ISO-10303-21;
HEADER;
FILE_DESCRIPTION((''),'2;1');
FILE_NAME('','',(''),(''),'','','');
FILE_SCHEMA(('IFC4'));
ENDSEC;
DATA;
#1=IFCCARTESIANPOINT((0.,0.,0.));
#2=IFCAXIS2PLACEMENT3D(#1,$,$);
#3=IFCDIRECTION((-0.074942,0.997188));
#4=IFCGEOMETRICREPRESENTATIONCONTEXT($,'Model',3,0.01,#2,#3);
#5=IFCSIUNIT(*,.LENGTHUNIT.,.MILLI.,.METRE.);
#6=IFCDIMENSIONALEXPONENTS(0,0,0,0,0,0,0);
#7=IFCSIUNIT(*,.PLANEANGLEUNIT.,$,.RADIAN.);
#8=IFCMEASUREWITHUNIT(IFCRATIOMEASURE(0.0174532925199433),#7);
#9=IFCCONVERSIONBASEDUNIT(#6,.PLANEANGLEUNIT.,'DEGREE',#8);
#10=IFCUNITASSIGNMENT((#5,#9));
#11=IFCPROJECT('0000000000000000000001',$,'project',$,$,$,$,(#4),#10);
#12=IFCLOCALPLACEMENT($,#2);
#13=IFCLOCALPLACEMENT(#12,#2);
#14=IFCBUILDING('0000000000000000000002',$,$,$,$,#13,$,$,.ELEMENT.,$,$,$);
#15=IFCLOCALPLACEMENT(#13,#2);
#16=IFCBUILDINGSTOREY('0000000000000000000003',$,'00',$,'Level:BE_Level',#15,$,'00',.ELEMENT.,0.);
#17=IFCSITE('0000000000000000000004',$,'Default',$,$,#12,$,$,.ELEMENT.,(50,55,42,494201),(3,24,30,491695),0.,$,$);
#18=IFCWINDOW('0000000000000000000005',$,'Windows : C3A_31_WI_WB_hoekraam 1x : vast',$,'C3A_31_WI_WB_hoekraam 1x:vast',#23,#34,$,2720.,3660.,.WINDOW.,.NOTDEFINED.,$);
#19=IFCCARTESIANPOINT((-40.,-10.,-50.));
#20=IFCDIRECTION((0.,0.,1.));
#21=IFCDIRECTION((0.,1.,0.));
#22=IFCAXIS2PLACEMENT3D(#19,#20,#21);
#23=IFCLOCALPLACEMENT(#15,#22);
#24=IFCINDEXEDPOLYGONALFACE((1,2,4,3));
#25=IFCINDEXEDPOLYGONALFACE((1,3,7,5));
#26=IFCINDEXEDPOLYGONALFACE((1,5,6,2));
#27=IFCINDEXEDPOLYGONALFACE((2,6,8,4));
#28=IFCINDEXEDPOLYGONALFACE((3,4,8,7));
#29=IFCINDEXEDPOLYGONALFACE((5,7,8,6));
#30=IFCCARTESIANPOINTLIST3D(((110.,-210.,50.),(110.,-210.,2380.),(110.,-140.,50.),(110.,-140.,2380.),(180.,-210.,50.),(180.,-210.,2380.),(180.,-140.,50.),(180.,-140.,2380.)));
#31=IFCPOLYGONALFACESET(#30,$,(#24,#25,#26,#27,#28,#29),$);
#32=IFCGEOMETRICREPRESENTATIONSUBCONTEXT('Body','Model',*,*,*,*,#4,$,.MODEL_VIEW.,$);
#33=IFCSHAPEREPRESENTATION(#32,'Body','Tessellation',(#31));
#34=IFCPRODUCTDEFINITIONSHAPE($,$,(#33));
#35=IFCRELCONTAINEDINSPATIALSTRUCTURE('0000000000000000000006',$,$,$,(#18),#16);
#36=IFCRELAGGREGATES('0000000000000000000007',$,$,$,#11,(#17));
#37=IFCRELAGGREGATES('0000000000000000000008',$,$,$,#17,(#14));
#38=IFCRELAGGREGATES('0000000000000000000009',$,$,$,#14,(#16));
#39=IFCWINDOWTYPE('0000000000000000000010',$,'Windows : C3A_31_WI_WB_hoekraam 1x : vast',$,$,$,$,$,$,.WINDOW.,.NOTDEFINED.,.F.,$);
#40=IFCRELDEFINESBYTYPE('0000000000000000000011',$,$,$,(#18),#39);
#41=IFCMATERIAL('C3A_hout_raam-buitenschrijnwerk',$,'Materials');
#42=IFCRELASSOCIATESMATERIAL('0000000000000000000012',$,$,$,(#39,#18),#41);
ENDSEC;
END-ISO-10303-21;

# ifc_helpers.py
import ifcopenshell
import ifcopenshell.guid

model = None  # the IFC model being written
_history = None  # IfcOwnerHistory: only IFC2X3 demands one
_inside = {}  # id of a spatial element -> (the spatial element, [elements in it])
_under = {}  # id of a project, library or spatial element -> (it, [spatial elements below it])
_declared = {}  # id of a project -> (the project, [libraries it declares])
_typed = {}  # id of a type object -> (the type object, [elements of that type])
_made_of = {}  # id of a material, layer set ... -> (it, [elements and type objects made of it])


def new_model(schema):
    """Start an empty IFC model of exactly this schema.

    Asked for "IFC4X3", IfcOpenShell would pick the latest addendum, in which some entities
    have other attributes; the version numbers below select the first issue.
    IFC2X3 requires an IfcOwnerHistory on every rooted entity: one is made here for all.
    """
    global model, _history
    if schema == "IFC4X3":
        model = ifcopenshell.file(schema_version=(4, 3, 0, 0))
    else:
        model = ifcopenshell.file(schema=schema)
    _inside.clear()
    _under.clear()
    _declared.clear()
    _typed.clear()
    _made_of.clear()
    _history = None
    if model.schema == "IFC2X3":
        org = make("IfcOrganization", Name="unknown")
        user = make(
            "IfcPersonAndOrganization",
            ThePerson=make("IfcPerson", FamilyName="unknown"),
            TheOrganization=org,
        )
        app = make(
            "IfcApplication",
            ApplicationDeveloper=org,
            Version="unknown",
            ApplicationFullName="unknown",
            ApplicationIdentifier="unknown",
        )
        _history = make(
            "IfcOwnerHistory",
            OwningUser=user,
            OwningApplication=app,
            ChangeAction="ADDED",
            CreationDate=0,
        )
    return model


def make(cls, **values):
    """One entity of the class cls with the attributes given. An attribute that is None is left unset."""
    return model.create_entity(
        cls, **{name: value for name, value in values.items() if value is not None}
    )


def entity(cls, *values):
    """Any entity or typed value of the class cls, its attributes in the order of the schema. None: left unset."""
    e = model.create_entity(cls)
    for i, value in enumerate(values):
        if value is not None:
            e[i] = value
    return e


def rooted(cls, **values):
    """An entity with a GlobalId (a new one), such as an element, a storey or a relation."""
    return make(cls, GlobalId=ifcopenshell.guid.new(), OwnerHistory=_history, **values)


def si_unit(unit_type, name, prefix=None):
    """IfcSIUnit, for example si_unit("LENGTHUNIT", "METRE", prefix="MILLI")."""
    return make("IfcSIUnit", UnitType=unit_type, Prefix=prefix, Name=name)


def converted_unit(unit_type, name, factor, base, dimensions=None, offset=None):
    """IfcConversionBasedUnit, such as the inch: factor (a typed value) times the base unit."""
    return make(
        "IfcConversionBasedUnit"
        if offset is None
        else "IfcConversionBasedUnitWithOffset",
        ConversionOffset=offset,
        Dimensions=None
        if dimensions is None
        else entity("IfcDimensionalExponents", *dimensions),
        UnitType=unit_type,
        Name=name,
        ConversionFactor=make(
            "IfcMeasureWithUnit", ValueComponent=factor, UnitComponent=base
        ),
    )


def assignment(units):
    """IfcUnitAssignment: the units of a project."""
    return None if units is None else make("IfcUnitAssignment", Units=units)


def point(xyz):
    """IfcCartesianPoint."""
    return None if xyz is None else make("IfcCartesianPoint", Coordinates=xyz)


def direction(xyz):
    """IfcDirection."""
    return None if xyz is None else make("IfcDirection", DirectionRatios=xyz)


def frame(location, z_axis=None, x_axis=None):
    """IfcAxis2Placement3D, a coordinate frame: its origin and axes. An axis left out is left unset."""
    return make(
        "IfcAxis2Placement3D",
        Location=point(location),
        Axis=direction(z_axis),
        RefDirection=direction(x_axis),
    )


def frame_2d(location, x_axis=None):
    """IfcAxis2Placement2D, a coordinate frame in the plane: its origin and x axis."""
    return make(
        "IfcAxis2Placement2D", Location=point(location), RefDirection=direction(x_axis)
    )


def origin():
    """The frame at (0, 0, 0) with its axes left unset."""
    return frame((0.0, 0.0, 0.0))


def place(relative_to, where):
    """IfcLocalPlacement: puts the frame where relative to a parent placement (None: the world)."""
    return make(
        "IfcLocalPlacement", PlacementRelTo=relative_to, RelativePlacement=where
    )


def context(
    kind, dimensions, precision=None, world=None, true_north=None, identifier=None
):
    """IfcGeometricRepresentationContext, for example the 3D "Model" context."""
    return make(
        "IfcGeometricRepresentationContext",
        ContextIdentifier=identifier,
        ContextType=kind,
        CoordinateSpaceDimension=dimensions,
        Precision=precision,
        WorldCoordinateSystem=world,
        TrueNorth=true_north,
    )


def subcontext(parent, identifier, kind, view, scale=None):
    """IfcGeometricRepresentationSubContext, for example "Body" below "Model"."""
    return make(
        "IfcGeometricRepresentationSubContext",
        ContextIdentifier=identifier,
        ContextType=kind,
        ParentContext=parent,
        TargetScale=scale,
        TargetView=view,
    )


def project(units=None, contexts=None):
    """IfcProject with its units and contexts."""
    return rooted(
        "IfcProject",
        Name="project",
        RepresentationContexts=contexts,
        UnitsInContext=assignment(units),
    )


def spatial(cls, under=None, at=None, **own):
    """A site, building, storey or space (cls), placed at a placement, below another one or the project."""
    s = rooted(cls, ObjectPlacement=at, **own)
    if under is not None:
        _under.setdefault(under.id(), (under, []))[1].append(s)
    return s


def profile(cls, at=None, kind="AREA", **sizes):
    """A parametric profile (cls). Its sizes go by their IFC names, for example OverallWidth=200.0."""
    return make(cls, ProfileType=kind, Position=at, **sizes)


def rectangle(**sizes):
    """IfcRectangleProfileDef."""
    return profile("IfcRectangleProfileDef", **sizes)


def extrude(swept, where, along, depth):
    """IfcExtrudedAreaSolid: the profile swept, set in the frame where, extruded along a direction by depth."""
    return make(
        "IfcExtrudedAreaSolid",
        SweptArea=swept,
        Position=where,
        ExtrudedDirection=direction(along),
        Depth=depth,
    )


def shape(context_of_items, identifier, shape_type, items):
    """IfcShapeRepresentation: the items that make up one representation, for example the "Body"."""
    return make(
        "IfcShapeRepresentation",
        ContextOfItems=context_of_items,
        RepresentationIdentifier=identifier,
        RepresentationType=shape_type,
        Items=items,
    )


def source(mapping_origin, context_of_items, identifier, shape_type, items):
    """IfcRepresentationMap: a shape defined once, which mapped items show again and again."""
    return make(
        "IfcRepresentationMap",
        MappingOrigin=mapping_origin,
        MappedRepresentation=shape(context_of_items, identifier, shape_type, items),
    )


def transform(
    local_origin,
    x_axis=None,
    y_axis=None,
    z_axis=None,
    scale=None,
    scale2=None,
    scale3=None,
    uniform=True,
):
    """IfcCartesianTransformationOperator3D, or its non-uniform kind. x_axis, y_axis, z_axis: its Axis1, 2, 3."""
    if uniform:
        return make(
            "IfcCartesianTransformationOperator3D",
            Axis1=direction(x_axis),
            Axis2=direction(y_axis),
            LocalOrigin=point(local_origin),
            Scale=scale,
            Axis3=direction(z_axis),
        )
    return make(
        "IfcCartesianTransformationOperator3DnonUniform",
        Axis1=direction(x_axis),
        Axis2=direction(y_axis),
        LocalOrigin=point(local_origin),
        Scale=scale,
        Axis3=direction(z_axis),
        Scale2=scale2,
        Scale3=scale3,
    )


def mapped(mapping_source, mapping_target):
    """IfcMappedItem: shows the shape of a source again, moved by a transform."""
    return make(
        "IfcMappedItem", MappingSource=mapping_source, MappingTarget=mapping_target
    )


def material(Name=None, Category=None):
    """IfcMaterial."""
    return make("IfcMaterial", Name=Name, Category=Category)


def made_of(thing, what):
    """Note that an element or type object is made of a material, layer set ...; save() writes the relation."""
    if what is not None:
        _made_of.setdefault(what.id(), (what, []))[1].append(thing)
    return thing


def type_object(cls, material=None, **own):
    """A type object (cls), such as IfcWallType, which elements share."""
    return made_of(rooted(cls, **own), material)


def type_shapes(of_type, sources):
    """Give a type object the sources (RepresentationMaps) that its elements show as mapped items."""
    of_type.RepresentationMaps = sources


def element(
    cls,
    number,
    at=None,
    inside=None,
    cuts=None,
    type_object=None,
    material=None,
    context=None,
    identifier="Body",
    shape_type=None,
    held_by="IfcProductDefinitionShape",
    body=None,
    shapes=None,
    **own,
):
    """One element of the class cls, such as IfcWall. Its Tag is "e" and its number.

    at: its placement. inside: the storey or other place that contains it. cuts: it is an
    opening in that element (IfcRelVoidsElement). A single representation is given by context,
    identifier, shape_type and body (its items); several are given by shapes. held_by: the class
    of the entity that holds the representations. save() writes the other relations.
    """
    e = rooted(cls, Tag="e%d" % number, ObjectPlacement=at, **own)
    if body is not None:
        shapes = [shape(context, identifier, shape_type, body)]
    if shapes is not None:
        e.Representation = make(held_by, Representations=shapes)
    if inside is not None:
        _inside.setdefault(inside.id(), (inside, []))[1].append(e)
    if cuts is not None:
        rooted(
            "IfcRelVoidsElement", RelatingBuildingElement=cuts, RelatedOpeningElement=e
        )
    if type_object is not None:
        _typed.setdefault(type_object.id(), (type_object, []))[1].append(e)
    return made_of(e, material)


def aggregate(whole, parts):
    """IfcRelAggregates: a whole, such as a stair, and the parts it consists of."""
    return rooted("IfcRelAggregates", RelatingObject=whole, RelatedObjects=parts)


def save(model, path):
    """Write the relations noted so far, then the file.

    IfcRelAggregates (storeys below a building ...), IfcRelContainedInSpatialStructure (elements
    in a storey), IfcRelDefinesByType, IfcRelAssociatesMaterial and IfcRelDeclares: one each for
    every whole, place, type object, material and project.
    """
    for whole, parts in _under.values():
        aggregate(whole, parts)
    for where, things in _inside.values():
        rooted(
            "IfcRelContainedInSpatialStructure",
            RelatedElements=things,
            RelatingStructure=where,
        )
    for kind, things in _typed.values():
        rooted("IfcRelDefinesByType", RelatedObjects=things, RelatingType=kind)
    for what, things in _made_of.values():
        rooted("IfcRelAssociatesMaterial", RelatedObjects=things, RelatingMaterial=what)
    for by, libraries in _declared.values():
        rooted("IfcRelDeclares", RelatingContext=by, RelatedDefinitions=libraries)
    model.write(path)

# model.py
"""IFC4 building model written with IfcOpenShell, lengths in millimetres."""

from ifc_helpers import new_model, entity, si_unit, converted_unit, direction, frame, frame_2d, origin, place, context, subcontext, project, spatial, rectangle, extrude, source, transform, mapped, material, type_object, type_shapes, element, save


model = new_model("IFC4")

# Units and contexts
model_context = context("Model", 3, precision=0.01, world=origin(), true_north=direction((-0.074942, 0.997188)))
body_context = subcontext(model_context, "Body", "Model", "MODEL_VIEW")
ifc_project = project(units=[si_unit("LENGTHUNIT", "METRE", prefix="MILLI"), converted_unit("PLANEANGLEUNIT", "DEGREE", entity("IfcRatioMeasure", 0.0174532925199433), si_unit("PLANEANGLEUNIT", "RADIAN"), dimensions=[0, 0, 0, 0, 0, 0, 0])], contexts=[model_context])

# Site, building, storey
site_placement = place(None, origin())
site = spatial("IfcSite", under=ifc_project, at=site_placement, Name="Default", CompositionType="ELEMENT", RefLatitude=(50, 55, 42, 494201), RefLongitude=(3, 24, 30, 491695), RefElevation=0.0)
building_placement = place(site_placement, origin())
building = spatial("IfcBuilding", under=site, at=building_placement, CompositionType="ELEMENT")
storey_placement = place(building_placement, frame((0.0, 0.0, 0.0)))
storey = spatial("IfcBuildingStorey", under=building, at=storey_placement, Name="00", ObjectType="Level:BE_Level", LongName="00", CompositionType="ELEMENT", Elevation=0.0)

# Window
ifc_material_1 = material(Name="C3A_hout_raam-buitenschrijnwerk", Category="Materials")
window_type = type_object("IfcWindowType", Name="Windows : C3A_31_WI_WB_hoekraam 1x : vast", ParameterTakesPrecedence=False, PartitioningType="NOTDEFINED", PredefinedType="WINDOW", material=ifc_material_1)
shared_shape_1 = source(origin(), body_context, "Body", "SweptSolid", [
    extrude(rectangle(XDim=70.0, YDim=70.0, at=frame_2d((0.0, 0.0), x_axis=(1.0, 0.0))), frame((145.0, -175.0, 50.0), z_axis=(0.0, 0.0, 1.0), x_axis=(0.0, 1.0, 0.0)), (0.0, 0.0, 1.0), 2330.0),
])
type_shapes(window_type, [shared_shape_1])
window_placement = place(storey_placement, frame((-40.0, -10.0, -50.0), z_axis=(0.0, 0.0, 1.0), x_axis=(0.0, 1.0, 0.0)))
element("IfcWindow", 1, at=window_placement, inside=storey, type_object=window_type, material=ifc_material_1, Name="Windows : C3A_31_WI_WB_hoekraam 1x : vast", ObjectType="C3A_31_WI_WB_hoekraam 1x:vast", OverallHeight=2720.0, OverallWidth=3660.0, PartitioningType="NOTDEFINED", PredefinedType="WINDOW", context=body_context, shape_type="MappedRepresentation", body=[
    mapped(shared_shape_1, transform((0.0, 0.0, 0.0), scale=1.0)),
])

save(model, "model.ifc")
